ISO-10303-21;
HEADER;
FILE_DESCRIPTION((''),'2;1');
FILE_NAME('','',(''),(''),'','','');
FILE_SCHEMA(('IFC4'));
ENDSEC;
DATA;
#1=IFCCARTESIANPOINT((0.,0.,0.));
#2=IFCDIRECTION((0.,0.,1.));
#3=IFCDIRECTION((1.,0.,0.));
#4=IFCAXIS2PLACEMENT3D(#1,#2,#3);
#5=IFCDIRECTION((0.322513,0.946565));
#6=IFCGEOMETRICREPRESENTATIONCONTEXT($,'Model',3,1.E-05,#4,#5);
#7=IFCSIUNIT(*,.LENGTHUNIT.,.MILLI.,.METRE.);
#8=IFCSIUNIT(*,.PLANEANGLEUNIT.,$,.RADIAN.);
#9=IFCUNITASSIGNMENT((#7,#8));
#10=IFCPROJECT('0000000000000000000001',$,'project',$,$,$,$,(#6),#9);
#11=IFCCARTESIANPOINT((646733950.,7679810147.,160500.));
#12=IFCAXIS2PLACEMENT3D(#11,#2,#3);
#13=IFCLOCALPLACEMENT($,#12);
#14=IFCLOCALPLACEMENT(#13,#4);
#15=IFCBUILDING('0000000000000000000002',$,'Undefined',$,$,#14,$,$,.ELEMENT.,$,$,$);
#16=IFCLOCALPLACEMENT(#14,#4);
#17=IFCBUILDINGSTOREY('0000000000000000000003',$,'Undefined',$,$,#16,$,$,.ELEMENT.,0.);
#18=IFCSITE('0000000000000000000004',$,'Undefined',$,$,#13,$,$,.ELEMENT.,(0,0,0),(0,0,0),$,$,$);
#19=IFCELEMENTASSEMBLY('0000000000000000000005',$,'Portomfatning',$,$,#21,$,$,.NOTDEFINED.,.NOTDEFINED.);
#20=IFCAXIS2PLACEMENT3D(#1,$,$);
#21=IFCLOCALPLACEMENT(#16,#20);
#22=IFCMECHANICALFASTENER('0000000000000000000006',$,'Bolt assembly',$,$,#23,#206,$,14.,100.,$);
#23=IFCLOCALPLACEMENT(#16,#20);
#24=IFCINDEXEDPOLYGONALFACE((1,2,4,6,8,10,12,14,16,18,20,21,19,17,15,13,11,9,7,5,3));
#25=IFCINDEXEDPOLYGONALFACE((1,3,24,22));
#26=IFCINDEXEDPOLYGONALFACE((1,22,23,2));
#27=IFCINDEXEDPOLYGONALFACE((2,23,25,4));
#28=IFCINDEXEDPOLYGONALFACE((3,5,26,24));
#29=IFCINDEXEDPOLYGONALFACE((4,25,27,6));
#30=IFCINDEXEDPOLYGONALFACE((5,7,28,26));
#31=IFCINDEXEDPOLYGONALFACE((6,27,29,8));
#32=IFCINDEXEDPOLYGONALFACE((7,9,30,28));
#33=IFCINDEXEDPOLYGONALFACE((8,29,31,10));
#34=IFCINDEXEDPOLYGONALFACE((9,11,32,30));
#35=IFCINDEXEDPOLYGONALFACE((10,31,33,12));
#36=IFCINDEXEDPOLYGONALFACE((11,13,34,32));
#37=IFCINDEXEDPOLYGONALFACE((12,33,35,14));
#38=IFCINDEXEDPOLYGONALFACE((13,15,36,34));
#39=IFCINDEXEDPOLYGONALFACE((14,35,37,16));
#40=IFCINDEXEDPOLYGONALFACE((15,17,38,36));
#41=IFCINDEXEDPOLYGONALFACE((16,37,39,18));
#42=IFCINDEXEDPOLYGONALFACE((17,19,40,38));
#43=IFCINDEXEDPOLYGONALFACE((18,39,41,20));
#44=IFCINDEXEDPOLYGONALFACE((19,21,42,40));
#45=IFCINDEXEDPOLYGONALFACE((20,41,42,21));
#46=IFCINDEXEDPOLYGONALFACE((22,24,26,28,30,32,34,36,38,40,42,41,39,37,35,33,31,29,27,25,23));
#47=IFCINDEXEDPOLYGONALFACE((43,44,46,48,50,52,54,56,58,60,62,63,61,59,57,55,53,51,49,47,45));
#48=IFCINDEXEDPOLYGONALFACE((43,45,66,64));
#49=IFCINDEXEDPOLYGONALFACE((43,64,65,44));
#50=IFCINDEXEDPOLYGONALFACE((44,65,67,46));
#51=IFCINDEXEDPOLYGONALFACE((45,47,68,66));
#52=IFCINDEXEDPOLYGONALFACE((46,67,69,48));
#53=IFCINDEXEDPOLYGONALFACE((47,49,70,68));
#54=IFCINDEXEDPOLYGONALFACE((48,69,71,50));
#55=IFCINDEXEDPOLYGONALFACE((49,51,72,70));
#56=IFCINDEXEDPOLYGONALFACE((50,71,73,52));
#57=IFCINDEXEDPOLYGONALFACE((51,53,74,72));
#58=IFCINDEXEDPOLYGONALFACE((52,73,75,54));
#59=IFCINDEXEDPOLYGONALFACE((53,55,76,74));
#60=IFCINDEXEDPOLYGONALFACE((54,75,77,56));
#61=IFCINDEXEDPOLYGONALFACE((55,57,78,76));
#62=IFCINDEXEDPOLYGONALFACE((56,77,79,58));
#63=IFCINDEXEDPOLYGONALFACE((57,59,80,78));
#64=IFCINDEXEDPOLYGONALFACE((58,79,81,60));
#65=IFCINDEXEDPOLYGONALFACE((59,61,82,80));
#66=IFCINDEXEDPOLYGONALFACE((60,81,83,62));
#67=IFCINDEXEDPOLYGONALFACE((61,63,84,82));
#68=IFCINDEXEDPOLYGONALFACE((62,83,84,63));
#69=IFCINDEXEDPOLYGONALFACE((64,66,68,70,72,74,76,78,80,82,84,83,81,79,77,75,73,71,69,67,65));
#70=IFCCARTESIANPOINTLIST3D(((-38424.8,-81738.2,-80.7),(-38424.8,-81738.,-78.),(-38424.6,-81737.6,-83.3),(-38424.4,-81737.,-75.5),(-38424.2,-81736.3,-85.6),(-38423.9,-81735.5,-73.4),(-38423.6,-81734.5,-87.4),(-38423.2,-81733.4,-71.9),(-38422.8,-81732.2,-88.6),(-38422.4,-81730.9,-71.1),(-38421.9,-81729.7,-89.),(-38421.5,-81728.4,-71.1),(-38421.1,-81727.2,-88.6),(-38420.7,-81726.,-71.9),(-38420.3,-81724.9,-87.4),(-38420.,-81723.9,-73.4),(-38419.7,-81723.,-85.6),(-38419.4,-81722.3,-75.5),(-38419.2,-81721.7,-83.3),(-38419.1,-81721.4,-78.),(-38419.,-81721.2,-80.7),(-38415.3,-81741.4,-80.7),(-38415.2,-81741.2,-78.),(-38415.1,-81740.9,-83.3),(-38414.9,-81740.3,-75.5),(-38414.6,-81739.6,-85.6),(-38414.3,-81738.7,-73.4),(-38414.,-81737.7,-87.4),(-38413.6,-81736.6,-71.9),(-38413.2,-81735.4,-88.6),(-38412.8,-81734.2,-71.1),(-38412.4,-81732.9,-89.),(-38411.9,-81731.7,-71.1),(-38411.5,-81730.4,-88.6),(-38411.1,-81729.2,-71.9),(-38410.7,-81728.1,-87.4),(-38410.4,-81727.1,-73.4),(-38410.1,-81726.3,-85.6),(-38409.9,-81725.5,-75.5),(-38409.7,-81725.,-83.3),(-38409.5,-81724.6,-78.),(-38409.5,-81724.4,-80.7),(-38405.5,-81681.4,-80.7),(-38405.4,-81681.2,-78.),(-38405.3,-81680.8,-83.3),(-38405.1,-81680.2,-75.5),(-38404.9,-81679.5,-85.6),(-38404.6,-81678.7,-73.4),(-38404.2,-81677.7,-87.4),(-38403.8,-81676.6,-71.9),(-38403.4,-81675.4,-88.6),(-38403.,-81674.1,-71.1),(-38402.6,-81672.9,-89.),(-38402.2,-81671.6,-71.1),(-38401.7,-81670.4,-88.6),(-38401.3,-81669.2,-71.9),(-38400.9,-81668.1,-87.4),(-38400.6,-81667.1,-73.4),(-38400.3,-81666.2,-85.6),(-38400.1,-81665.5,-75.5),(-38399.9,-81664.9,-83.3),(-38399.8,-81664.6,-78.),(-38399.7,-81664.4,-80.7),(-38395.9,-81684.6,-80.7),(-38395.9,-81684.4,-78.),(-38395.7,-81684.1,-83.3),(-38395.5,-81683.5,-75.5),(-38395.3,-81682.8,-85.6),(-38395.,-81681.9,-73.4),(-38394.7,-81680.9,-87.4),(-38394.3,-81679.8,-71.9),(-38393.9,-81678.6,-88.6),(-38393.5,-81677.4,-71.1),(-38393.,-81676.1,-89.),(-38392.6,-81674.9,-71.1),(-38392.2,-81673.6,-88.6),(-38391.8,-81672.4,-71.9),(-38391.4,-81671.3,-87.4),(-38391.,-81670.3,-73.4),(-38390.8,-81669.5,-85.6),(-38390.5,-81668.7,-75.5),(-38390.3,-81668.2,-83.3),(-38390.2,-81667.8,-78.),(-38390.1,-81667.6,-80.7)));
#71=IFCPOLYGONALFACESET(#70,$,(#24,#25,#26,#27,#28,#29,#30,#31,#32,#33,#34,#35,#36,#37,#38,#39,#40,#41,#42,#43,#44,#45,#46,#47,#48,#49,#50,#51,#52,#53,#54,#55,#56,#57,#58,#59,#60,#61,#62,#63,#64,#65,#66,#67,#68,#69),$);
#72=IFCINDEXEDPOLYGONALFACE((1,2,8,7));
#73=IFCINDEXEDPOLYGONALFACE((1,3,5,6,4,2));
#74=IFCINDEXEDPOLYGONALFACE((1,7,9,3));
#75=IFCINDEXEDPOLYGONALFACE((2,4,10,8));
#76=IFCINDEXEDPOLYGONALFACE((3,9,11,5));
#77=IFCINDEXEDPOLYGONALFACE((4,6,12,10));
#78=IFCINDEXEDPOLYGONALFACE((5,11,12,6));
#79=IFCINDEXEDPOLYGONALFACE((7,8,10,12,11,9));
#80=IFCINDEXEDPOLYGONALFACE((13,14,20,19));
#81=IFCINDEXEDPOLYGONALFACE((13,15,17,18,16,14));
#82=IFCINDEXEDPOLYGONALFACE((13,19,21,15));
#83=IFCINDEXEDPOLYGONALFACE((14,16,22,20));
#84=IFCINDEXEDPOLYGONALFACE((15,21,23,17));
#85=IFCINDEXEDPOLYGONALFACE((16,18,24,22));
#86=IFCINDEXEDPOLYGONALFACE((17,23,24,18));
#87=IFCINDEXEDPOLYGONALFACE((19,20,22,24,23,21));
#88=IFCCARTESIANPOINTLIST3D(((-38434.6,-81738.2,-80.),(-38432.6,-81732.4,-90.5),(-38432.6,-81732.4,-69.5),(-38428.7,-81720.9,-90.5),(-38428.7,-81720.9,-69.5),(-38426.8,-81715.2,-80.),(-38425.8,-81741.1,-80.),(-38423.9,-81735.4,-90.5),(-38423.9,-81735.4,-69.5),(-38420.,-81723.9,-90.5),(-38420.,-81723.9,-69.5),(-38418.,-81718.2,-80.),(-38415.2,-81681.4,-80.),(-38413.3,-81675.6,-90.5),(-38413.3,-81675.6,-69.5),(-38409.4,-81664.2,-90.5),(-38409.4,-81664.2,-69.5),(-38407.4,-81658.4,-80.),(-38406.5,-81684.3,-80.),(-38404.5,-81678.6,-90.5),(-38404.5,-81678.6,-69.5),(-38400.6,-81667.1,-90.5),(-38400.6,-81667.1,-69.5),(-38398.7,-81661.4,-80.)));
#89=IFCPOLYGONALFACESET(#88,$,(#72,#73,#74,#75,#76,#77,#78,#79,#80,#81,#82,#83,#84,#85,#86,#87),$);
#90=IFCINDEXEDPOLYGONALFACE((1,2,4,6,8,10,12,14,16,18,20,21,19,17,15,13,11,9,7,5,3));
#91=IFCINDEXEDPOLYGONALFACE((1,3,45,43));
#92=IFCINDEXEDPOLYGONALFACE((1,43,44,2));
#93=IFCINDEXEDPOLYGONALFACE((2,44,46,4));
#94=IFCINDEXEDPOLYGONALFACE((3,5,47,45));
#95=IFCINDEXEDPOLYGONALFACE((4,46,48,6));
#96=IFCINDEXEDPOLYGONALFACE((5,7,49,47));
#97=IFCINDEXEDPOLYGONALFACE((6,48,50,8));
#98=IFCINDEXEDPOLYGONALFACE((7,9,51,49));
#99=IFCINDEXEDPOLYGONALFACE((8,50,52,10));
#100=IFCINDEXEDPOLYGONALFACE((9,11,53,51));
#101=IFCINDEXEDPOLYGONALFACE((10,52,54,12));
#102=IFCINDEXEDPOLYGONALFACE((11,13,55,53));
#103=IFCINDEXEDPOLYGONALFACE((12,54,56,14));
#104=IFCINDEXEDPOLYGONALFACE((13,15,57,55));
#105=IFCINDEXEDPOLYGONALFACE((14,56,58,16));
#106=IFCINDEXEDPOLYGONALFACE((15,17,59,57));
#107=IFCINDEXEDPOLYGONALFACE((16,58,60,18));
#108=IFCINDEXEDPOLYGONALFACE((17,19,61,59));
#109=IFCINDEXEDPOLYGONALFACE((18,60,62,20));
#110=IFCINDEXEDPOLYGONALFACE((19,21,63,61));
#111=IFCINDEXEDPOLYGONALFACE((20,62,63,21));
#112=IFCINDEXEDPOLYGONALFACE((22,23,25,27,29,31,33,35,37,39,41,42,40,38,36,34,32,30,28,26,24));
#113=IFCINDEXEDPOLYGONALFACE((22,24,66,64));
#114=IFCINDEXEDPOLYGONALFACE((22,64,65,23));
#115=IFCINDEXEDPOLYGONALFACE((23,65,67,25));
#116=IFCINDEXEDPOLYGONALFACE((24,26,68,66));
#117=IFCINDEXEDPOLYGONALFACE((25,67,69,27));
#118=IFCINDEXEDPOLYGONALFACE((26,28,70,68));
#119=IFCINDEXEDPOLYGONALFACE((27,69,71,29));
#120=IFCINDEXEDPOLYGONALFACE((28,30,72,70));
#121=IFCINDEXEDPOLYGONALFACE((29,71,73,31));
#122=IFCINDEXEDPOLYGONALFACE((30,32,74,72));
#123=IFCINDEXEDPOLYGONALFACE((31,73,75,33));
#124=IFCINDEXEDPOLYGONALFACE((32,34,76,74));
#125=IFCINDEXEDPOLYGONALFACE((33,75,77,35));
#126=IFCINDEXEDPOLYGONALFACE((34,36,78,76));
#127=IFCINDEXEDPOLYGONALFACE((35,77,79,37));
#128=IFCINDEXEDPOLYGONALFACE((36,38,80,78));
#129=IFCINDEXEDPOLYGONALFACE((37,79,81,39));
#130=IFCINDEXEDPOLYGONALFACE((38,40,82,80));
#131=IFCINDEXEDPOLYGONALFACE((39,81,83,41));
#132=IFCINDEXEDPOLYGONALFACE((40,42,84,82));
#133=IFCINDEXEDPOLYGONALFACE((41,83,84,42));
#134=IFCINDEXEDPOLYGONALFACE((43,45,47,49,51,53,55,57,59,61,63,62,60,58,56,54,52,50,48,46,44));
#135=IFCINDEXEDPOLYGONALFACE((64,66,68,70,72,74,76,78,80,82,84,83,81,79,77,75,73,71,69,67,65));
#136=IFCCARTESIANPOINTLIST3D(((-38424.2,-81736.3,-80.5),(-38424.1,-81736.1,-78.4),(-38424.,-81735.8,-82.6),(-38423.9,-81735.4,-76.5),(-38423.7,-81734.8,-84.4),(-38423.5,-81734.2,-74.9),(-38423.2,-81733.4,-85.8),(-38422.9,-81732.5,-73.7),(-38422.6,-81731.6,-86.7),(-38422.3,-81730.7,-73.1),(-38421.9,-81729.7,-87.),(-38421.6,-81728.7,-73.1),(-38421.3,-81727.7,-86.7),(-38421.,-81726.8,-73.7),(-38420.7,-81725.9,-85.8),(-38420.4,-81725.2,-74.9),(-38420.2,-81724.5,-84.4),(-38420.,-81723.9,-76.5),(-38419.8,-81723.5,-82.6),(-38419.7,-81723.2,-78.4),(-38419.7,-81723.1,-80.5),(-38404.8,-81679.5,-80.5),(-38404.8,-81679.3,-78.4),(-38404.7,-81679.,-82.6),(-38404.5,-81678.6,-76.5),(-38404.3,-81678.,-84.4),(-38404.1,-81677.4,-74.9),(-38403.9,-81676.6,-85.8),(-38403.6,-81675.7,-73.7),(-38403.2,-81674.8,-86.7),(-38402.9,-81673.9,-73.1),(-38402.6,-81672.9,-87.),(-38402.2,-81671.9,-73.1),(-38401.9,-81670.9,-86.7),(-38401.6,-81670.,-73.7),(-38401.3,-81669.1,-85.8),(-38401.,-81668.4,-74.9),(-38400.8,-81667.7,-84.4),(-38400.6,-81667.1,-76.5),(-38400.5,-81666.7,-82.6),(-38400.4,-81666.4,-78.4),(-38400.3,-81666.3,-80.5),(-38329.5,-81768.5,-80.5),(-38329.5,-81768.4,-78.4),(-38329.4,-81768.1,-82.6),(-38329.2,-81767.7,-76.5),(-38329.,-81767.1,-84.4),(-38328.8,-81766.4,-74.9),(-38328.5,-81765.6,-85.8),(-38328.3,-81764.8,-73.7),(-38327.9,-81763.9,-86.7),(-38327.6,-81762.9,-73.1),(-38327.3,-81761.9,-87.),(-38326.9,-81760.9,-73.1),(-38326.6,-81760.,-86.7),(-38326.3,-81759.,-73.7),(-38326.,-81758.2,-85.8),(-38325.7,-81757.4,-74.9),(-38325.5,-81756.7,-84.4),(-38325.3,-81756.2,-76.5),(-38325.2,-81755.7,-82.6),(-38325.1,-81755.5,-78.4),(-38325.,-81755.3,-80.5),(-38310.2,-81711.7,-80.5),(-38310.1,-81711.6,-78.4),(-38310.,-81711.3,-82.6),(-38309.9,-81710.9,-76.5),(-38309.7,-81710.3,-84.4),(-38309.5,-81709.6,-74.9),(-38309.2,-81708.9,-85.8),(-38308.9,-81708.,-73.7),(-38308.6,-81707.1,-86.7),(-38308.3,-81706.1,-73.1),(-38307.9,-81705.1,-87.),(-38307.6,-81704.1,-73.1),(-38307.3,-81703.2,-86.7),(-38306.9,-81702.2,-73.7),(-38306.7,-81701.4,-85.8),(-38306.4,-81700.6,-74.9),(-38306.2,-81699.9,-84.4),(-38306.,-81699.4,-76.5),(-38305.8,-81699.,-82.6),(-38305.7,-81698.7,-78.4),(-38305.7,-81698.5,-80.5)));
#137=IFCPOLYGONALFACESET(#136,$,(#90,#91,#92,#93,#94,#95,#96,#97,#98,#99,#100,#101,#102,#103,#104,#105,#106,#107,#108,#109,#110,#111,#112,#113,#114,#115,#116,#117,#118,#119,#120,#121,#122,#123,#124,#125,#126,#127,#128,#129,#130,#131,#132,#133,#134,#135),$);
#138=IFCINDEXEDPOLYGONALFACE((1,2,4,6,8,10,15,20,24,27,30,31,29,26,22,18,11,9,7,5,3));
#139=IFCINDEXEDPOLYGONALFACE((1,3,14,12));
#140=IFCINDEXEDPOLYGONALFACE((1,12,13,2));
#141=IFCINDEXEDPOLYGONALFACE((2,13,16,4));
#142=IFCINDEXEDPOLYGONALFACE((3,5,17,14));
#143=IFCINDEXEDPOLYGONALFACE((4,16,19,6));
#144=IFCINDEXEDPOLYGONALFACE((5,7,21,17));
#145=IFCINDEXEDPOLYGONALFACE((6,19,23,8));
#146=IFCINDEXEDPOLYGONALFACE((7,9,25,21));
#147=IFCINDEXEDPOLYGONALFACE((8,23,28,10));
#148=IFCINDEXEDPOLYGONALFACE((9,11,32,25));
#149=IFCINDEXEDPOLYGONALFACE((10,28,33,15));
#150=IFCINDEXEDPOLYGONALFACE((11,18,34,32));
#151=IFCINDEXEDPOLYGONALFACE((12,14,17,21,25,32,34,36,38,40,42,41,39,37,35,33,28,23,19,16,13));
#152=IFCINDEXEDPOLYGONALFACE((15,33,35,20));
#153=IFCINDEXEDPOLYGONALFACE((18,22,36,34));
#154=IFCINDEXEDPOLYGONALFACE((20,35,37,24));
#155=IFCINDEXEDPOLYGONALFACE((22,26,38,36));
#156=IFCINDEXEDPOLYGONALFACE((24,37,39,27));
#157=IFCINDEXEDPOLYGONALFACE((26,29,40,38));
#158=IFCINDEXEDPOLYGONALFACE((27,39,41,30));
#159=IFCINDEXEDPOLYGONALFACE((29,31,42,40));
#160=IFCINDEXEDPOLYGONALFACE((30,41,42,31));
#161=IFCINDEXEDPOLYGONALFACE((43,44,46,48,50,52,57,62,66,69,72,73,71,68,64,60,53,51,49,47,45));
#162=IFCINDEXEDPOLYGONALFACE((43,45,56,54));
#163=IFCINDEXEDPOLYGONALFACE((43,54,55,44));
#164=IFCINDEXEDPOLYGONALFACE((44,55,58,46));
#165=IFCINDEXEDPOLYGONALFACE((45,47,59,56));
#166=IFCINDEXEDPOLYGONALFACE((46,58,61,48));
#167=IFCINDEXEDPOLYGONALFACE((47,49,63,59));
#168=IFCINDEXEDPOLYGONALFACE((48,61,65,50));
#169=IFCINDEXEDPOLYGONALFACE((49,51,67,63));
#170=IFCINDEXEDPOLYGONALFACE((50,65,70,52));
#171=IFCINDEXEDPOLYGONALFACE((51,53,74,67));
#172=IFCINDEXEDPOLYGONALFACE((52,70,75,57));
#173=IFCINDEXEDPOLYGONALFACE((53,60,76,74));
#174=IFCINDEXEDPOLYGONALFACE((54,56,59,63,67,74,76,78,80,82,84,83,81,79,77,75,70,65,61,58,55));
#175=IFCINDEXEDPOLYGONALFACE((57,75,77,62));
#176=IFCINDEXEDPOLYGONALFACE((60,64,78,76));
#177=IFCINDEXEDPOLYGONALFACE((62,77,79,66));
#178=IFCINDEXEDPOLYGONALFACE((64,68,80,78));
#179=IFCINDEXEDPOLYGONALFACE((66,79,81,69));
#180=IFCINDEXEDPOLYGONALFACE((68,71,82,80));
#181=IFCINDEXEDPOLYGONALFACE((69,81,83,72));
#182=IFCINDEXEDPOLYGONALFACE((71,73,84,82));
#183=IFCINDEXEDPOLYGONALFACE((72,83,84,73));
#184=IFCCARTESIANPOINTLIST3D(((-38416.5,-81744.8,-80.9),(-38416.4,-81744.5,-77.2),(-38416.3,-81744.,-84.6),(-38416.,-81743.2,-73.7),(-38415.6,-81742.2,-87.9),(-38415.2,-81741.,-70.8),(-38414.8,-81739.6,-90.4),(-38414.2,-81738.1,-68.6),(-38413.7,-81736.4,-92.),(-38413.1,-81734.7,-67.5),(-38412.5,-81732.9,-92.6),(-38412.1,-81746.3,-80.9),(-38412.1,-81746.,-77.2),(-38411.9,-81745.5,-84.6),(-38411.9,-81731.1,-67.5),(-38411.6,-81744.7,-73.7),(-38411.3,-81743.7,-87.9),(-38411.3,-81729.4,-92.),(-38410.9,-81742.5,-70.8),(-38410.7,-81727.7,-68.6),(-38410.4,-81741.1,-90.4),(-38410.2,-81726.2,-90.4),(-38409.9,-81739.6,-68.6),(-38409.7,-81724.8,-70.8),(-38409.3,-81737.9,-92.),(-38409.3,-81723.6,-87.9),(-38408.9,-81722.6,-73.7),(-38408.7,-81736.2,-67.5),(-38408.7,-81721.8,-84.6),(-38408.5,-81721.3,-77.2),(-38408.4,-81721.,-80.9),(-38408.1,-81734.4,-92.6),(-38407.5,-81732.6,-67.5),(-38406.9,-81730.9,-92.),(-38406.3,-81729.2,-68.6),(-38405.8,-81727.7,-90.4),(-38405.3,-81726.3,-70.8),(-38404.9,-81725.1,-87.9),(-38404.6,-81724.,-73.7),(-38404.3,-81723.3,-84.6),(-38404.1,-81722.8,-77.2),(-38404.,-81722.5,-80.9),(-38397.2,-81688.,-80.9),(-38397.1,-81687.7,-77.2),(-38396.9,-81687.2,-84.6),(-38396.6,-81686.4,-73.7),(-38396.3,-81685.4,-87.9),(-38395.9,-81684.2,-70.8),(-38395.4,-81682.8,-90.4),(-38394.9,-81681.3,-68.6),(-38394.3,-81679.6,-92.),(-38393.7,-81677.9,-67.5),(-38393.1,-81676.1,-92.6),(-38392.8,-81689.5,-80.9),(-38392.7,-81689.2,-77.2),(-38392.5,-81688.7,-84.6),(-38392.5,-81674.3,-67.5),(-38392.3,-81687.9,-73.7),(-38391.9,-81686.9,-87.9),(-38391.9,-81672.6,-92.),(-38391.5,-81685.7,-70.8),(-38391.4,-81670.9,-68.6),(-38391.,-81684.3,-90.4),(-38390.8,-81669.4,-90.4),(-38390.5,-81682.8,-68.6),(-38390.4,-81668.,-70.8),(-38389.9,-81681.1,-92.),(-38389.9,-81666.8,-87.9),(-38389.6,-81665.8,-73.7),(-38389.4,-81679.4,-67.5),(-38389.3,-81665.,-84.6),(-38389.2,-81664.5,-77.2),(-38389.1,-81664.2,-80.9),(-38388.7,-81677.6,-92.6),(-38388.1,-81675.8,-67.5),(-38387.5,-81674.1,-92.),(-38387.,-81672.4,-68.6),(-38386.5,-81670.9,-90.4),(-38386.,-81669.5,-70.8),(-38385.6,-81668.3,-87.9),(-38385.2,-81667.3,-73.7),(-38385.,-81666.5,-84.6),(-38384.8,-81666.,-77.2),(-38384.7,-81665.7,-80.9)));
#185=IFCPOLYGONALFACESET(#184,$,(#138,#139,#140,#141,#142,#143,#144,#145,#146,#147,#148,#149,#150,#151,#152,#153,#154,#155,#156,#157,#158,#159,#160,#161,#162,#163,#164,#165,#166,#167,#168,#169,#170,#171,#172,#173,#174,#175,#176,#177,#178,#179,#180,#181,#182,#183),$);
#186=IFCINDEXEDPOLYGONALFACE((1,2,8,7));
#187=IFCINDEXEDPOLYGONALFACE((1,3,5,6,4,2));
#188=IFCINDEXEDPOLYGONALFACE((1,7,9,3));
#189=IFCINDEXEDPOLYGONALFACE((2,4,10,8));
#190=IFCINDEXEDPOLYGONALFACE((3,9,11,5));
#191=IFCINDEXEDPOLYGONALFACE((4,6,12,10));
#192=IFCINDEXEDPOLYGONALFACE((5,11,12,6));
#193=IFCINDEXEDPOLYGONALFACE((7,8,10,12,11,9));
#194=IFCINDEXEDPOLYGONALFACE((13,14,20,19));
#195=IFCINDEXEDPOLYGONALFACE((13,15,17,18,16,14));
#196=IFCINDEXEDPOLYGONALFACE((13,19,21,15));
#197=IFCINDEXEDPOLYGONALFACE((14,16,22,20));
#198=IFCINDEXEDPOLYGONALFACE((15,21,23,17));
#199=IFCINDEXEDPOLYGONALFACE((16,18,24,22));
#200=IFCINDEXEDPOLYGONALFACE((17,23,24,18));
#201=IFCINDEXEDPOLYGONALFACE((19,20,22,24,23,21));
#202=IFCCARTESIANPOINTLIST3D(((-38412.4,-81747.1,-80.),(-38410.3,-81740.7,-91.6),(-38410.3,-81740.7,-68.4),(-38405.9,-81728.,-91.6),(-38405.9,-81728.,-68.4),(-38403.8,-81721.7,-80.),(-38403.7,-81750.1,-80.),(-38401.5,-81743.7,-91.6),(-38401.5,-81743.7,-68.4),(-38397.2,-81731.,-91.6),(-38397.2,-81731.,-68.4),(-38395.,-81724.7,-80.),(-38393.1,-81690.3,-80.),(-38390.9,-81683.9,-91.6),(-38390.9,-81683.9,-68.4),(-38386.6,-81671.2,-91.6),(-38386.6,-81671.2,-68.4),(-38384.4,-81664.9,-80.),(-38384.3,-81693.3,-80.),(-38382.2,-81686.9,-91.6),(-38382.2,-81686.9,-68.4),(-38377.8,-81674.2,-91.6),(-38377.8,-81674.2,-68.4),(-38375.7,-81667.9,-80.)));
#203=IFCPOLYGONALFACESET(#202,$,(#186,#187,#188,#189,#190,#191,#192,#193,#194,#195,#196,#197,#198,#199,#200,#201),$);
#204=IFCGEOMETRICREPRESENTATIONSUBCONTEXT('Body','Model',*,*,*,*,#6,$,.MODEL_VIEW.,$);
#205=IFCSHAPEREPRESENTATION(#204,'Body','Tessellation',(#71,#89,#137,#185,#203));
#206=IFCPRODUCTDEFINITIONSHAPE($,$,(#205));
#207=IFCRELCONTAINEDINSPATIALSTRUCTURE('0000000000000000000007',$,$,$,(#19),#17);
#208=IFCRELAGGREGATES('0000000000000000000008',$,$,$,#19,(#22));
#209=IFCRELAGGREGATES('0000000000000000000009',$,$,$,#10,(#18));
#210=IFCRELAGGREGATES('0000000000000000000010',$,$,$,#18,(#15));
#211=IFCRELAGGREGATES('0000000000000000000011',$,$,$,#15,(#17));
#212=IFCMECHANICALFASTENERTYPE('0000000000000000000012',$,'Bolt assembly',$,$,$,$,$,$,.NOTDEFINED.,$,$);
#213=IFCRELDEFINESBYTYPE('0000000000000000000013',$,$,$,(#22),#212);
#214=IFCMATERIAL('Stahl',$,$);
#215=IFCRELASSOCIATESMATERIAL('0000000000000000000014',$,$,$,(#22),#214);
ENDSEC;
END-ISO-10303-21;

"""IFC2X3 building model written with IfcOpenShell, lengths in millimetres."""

from ifc_helpers import new_model, si_unit, direction, frame, origin_with_axes, origin_2d_with_axis, place, context, subcontext, project, spatial, polyline, circle, outline, extrude, source, transform, mapped, material, type_object, element, aggregate, save


model = new_model("IFC2X3")

# Units and contexts
model_context = context("Model", 3, precision=1e-05, world=origin_with_axes(), true_north=direction((0.322513, 0.946565)))
body_context = subcontext(model_context, "Body", "Model", "MODEL_VIEW")
ifc_project = project(units=[si_unit("LENGTHUNIT", "METRE", prefix="MILLI"), si_unit("PLANEANGLEUNIT", "RADIAN")], contexts=[model_context])

# Site, building, storey
site_placement = place(None, frame((646733950.0, 7679810147.0, 160500.0), z_axis=(0.0, 0.0, 1.0), x_axis=(1.0, 0.0, 0.0)))
site = spatial("IfcSite", under=ifc_project, at=site_placement, Name="Undefined", CompositionType="ELEMENT", RefLatitude=(0, 0, 0), RefLongitude=(0, 0, 0))
building_placement = place(site_placement, origin_with_axes())
building = spatial("IfcBuilding", under=site, at=building_placement, Name="Undefined", CompositionType="ELEMENT")
storey_placement = place(building_placement, origin_with_axes())
storey = spatial("IfcBuildingStorey", under=building, at=storey_placement, Name="Undefined", CompositionType="ELEMENT", Elevation=0.0)

# Element assembly
assembly_1_placement = place(storey_placement, origin_with_axes())
assembly_1 = element("IfcElementAssembly", 1, at=assembly_1_placement, inside=storey, Name="Portomfatning", AssemblyPlace="NOTDEFINED", PredefinedType="NOTDEFINED")

# Mechanical fastener
ifc_material_1 = material(Name="Stahl")
mechanical_fastener_type = type_object("IfcMechanicalFastenerType", Name="Bolt assembly")
shared_shape_1 = source(origin_with_axes(), body_context, "Body", "SweptSolid", [
    extrude(circle(Radius=9.0, at=origin_2d_with_axis()), frame((0.0, -10.0, 0.0), z_axis=(0.0, 1.0, 0.0), x_axis=(1.0, 0.0, 0.0)), (0.0, 0.0, 1.0), 10.1),
    extrude(outline(polyline([(10.5, -6.1), (10.5, 6.1), (0.0, 12.1), (-10.5, 6.1), (-10.5, -6.1), (0.0, -12.1), (10.5, -6.1)])), frame((0.0, -19.2, 0.0), z_axis=(0.0, 1.0, 0.0), x_axis=(1.0, 0.0, 0.0)), (0.0, 0.0, 1.0), 9.2),
    extrude(circle(Radius=7.0, at=origin_2d_with_axis()), frame((0.0, -10.0, 0.0), z_axis=(0.0, 1.0, 0.0), x_axis=(1.0, 0.0, 0.0)), (0.0, 0.0, 1.0), 100.0),
    extrude(circle(Radius=12.6, at=origin_2d_with_axis()), frame((0.0, 0.0, 0.0), z_axis=(0.0, 1.0, 0.0), x_axis=(1.0, 0.0, 0.0)), (0.0, 0.0, 1.0), 4.6),
    extrude(outline(polyline([(11.6, -6.7), (11.6, 6.7), (0.0, 13.4), (-11.6, 6.7), (-11.6, -6.7), (0.0, -13.4), (11.6, -6.7)])), frame((0.0, 4.6, 0.0), z_axis=(0.0, 1.0, 0.0), x_axis=(1.0, 0.0, 0.0)), (0.0, 0.0, 1.0), 9.2),
])
mechanical_fastener_1_placement = place(assembly_1_placement, frame((-38402.8, -81704.5, -80.0), z_axis=(-0.322513, -0.946565, 0.0), x_axis=(0.0, 0.0, -1.0)))
mechanical_fastener_1 = element("IfcMechanicalFastener", 2, at=mechanical_fastener_1_placement, type_object=mechanical_fastener_type, material=ifc_material_1, Name="Bolt assembly", NominalDiameter=14.0, NominalLength=100.0, context=body_context, shape_type="MappedRepresentation", body=[
    mapped(shared_shape_1, transform((0.0, 0.0, -30.0))),
    mapped(shared_shape_1, transform((0.0, 0.0, 30.0))),
])
aggregate(assembly_1, [mechanical_fastener_1])

save(model, "model.ifc")
